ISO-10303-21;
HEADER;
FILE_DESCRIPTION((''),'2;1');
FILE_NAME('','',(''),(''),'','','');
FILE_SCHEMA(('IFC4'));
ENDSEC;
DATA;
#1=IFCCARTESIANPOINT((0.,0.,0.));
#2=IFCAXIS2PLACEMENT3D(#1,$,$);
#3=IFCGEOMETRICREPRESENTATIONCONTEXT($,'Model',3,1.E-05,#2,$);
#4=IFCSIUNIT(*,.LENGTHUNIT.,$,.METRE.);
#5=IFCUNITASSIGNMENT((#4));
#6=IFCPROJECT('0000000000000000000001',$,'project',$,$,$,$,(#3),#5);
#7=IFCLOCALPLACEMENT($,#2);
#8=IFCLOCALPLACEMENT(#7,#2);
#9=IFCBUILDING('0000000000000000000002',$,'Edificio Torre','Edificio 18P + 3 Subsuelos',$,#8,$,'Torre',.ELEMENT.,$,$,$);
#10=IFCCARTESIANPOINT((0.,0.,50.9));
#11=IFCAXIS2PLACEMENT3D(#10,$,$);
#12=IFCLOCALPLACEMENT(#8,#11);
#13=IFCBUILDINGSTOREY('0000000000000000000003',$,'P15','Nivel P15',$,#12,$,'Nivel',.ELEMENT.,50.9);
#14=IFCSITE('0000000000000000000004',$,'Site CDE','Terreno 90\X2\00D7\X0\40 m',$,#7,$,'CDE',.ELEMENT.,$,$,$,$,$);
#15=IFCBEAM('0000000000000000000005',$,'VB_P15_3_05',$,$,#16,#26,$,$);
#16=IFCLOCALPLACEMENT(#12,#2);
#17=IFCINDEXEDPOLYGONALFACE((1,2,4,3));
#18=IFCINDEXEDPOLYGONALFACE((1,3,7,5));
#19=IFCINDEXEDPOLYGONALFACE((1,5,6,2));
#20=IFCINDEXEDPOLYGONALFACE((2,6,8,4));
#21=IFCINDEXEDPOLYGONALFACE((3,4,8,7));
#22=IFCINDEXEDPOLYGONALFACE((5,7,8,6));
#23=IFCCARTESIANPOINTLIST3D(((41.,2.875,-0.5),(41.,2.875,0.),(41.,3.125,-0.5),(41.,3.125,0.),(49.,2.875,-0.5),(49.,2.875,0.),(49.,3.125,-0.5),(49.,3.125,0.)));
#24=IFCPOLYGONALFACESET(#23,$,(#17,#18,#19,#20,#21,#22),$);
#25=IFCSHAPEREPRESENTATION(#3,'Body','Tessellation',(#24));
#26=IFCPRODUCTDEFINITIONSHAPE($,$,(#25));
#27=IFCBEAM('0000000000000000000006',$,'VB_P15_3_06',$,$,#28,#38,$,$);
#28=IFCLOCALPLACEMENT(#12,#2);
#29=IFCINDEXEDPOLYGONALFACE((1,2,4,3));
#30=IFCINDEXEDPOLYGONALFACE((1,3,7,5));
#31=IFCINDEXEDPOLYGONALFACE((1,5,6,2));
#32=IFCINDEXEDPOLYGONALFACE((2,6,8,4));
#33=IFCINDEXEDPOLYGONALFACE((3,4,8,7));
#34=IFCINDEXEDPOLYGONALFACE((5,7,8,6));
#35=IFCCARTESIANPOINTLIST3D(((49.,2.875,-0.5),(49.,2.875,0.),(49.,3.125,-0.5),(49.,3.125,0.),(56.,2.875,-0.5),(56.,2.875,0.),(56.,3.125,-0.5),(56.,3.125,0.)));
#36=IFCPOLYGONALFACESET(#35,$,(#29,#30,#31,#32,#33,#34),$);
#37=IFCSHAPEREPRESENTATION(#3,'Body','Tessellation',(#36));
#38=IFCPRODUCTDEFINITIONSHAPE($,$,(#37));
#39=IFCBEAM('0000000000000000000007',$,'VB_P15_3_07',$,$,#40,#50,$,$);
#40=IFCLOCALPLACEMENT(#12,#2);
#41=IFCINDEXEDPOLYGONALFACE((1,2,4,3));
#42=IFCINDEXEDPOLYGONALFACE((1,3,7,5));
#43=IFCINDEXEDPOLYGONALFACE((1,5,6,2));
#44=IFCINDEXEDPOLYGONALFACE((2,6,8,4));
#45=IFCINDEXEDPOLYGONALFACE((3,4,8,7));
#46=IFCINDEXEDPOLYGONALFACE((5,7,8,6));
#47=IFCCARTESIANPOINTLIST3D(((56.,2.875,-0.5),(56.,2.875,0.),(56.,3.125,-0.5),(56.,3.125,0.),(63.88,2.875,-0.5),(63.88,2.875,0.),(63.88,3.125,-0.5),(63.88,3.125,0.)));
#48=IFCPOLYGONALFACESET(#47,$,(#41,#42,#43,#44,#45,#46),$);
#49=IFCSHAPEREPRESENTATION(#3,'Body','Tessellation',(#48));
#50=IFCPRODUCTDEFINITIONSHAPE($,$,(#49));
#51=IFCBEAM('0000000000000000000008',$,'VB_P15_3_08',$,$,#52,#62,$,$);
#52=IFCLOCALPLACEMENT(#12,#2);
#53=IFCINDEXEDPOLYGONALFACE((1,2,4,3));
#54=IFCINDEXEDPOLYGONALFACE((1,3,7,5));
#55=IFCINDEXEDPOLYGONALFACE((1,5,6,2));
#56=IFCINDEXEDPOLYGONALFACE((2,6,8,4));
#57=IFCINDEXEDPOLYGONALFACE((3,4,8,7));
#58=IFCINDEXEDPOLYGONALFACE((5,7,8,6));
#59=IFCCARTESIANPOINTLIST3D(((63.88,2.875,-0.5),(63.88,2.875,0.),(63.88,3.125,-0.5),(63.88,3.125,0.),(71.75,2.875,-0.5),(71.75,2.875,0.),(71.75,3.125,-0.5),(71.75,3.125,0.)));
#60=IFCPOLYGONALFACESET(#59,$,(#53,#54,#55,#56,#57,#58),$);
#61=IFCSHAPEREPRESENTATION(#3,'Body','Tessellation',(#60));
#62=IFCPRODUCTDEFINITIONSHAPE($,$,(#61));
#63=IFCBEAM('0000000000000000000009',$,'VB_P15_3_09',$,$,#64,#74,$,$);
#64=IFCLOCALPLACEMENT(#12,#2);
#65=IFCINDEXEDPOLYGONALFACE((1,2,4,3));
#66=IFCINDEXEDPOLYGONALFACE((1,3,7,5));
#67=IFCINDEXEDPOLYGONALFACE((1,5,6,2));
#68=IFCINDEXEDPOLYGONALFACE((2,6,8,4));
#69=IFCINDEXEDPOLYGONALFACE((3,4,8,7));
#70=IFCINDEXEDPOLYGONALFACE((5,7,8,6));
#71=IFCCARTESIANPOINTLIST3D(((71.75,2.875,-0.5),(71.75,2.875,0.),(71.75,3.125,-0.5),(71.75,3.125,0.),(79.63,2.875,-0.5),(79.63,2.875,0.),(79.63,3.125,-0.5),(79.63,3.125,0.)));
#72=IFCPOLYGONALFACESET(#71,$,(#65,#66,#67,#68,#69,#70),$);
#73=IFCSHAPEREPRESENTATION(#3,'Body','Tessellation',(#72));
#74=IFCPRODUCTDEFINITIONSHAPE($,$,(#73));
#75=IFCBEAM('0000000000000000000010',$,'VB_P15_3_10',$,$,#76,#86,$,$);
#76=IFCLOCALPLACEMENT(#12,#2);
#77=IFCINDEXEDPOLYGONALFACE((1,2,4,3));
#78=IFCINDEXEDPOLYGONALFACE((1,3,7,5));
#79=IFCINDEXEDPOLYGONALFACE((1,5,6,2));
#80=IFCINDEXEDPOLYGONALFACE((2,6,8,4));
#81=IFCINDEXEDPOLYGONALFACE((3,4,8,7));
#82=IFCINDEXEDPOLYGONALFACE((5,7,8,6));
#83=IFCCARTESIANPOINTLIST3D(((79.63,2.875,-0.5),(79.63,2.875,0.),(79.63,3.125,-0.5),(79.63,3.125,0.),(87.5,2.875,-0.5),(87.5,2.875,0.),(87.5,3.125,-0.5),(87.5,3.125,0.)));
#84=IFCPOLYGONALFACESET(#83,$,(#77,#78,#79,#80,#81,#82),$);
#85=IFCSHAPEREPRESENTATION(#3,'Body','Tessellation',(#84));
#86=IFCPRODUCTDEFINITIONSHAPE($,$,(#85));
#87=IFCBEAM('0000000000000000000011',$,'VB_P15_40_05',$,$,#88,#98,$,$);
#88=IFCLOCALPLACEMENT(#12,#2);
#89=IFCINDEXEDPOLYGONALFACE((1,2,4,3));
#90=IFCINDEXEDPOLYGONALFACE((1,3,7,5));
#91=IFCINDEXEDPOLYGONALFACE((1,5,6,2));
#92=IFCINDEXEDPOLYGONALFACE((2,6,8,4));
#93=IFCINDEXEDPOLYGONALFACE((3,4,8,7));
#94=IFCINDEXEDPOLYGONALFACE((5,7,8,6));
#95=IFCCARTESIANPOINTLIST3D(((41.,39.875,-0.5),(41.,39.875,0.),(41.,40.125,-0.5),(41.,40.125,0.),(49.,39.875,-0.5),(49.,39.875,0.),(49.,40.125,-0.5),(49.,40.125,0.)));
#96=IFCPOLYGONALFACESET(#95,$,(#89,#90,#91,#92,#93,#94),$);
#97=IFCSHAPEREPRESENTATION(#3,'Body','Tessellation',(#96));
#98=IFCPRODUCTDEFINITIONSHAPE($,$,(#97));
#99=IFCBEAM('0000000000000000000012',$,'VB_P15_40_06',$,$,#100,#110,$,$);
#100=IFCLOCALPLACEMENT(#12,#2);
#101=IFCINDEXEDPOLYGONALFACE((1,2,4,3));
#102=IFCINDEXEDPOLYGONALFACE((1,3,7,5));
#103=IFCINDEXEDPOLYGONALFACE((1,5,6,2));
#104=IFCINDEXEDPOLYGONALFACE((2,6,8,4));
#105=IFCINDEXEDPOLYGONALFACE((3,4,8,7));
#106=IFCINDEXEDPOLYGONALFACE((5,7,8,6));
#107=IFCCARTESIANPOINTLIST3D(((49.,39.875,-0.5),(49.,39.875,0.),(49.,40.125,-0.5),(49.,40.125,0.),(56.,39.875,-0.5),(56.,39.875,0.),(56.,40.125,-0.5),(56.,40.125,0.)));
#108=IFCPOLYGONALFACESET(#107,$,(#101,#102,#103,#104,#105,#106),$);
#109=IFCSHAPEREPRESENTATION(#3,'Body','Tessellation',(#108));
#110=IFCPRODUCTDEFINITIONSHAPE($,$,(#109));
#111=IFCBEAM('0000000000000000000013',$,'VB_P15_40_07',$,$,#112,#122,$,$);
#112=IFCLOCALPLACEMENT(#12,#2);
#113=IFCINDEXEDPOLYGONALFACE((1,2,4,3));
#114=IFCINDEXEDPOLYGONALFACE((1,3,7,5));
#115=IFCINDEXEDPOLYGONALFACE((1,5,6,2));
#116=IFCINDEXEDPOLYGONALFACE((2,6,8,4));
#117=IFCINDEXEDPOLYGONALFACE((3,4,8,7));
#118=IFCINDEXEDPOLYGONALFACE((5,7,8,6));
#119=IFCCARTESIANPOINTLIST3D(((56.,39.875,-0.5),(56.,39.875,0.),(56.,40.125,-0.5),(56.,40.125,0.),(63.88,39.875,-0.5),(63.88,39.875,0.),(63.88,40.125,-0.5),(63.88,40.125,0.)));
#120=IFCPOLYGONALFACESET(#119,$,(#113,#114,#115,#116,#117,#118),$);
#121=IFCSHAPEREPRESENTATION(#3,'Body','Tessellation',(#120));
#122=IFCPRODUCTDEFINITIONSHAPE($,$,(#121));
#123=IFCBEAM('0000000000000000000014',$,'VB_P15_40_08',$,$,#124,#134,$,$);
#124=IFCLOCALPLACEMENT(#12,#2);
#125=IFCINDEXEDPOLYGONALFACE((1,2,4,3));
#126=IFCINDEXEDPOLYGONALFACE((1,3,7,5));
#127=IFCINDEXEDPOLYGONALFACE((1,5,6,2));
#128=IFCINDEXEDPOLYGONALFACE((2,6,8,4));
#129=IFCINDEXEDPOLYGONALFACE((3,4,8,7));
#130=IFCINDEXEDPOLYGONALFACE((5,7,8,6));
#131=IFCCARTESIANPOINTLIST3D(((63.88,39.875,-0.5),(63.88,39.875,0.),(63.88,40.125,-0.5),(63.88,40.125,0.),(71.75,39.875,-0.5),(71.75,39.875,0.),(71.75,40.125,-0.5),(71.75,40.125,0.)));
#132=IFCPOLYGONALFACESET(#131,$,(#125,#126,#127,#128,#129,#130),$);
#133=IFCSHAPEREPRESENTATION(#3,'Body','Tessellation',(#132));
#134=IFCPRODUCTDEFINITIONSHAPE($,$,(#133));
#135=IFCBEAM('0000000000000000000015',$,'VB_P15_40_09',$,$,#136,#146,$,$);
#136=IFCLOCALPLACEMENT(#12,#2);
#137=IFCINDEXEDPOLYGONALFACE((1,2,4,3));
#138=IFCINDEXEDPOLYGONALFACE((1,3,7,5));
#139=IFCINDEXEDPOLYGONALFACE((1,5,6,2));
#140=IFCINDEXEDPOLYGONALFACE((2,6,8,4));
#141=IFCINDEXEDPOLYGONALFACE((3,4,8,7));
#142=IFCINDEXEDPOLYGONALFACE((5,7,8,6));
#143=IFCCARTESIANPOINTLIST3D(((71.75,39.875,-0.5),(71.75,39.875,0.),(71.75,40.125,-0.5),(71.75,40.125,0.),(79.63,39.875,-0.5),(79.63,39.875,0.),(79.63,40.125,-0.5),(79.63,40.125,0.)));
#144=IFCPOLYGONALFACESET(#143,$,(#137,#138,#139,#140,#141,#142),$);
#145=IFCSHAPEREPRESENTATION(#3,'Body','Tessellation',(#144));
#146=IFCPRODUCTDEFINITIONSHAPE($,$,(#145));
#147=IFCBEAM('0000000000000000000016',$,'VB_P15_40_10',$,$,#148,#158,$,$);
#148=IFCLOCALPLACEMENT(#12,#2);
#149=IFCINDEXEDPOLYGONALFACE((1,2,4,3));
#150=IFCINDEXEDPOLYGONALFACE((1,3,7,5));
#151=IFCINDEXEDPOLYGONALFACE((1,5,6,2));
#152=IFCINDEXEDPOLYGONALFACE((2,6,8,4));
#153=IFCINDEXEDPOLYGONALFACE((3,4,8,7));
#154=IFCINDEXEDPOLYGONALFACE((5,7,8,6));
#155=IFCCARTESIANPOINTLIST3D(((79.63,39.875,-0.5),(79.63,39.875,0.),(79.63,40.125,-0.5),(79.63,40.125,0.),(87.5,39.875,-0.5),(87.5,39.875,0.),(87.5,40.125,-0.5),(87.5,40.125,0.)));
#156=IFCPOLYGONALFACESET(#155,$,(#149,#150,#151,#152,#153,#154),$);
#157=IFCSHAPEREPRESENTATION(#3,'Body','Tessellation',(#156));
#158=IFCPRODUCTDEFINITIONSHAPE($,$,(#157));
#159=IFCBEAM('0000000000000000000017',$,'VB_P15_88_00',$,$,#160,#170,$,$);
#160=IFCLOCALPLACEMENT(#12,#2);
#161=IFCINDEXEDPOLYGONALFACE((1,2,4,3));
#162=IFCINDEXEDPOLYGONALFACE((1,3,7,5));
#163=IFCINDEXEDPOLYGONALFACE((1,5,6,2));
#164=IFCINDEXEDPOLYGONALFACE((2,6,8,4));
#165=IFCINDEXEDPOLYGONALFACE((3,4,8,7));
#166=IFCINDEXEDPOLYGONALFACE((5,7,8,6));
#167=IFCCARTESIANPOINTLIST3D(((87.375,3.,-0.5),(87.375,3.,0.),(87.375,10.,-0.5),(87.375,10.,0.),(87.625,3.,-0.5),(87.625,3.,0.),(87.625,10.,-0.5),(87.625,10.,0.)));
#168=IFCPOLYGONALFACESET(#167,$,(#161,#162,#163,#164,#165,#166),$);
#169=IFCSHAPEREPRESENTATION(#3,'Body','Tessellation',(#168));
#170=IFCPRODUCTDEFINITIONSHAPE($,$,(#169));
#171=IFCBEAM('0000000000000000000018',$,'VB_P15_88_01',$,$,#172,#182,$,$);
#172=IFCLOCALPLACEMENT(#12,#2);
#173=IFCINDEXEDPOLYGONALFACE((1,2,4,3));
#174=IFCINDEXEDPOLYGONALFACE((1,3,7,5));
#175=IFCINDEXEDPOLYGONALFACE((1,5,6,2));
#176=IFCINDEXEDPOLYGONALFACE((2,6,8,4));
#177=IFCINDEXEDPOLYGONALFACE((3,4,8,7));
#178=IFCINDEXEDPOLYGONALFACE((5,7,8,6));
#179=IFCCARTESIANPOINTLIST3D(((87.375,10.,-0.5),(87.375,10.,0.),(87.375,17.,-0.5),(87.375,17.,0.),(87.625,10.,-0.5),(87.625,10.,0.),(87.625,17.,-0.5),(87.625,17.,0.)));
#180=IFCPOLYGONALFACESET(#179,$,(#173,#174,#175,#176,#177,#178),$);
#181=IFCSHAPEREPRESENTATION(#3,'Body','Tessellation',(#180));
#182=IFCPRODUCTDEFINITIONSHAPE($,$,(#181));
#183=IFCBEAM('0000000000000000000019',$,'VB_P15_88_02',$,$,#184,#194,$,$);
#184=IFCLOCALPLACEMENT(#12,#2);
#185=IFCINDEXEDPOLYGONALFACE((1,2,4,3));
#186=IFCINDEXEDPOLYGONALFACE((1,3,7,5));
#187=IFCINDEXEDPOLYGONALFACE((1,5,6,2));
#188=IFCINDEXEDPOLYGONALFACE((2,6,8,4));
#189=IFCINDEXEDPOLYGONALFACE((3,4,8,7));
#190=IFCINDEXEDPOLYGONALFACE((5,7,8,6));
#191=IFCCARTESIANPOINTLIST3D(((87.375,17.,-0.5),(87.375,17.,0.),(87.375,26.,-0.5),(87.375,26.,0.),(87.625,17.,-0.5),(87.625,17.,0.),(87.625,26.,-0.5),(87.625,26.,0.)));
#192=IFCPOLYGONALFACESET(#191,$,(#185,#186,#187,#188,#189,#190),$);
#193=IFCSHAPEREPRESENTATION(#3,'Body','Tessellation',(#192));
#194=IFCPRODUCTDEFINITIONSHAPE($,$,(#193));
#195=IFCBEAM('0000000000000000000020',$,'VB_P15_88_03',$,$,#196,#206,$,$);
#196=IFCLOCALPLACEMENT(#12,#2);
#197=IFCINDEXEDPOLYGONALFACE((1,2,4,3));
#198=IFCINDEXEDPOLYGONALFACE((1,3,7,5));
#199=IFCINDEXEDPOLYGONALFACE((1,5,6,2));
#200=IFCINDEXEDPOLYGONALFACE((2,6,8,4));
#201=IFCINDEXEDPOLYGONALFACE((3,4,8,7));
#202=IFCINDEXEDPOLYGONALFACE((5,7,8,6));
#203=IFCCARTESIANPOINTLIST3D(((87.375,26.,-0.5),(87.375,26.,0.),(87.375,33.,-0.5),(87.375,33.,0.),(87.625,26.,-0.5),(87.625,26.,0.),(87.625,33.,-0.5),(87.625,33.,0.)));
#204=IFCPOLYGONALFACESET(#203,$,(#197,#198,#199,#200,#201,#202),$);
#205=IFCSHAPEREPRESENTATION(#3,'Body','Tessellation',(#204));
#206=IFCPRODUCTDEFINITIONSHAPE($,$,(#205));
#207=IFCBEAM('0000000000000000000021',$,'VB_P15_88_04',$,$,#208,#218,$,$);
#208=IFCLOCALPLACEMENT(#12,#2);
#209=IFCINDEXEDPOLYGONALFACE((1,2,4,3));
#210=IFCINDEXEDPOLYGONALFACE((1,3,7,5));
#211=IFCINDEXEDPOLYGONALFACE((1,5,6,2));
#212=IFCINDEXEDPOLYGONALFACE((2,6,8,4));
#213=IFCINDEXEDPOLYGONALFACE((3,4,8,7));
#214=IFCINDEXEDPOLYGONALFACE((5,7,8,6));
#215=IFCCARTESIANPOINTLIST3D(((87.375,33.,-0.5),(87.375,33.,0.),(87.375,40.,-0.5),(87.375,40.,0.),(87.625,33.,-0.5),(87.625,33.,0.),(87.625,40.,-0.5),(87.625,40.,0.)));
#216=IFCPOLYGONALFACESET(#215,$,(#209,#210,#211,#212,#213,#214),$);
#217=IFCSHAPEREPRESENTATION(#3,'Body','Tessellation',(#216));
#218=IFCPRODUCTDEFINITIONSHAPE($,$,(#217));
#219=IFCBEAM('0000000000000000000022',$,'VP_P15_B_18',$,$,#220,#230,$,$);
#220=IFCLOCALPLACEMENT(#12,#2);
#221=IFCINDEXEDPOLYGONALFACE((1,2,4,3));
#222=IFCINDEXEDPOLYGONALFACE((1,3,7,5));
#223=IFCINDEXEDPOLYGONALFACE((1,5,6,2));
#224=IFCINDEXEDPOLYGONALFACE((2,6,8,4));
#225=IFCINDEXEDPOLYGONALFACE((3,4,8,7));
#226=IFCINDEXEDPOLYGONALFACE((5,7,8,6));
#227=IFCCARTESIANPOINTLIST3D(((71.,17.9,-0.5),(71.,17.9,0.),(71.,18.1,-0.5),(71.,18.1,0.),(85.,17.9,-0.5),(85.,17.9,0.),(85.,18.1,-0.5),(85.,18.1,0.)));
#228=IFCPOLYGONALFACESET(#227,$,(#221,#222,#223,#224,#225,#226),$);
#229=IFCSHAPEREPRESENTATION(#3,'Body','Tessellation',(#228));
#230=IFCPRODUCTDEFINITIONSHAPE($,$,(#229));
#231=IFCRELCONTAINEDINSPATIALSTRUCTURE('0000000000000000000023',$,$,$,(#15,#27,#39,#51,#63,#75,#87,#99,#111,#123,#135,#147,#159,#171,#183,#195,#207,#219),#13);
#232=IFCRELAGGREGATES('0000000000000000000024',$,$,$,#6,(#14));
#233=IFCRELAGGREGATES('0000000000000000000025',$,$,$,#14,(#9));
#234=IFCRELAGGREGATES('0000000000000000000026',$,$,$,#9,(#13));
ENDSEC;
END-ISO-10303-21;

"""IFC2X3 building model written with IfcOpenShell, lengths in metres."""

from ifc_helpers import new_model, si_unit, frame, origin, origin_2d, place, context, project, spatial, rectangle, extrude, element, save


model = new_model("IFC2X3")

# Units and contexts
model_context = context("Model", 3, precision=1e-05, world=origin())
ifc_project = project(units=[si_unit("LENGTHUNIT", "METRE")], contexts=[model_context])

# Site, building, storey
site_placement = place(None, origin())
site = spatial("IfcSite", under=ifc_project, at=site_placement, Name="Site CDE", Description="Terreno 90×40 m", LongName="CDE", CompositionType="ELEMENT")
building_placement = place(site_placement, origin())
building = spatial("IfcBuilding", under=site, at=building_placement, Name="Edificio Torre", Description="Edificio 18P + 3 Subsuelos", LongName="Torre", CompositionType="ELEMENT")
storey_placement = place(building_placement, frame((0.0, 0.0, 50.9)))
storey = spatial("IfcBuildingStorey", under=building, at=storey_placement, Name="P15", Description="Nivel P15", LongName="Nivel", CompositionType="ELEMENT", Elevation=50.9)

# Beams
beam_1_placement = place(storey_placement, frame((45.0, 3.0, -0.5)))
element("IfcBeam", 1, at=beam_1_placement, inside=storey, Name="VB_P15_3_05", context=model_context, shape_type="SweptSolid", body=[
    extrude(rectangle(XDim=8.0, YDim=0.25, at=origin_2d()), origin(), (0.0, 0.0, 1.0), 0.5),
])
beam_2_placement = place(storey_placement, frame((52.5, 3.0, -0.5)))
element("IfcBeam", 2, at=beam_2_placement, inside=storey, Name="VB_P15_3_06", context=model_context, shape_type="SweptSolid", body=[
    extrude(rectangle(XDim=7.0, YDim=0.25, at=origin_2d()), origin(), (0.0, 0.0, 1.0), 0.5),
])
beam_3_placement = place(storey_placement, frame((59.94, 3.0, -0.5)))
element("IfcBeam", 3, at=beam_3_placement, inside=storey, Name="VB_P15_3_07", context=model_context, shape_type="SweptSolid", body=[
    extrude(rectangle(XDim=7.88, YDim=0.25, at=origin_2d()), origin(), (0.0, 0.0, 1.0), 0.5),
])
beam_4_placement = place(storey_placement, frame((67.815, 3.0, -0.5)))
element("IfcBeam", 4, at=beam_4_placement, inside=storey, Name="VB_P15_3_08", context=model_context, shape_type="SweptSolid", body=[
    extrude(rectangle(XDim=7.87, YDim=0.25, at=origin_2d()), origin(), (0.0, 0.0, 1.0), 0.5),
])
beam_5_placement = place(storey_placement, frame((75.69, 3.0, -0.5)))
element("IfcBeam", 5, at=beam_5_placement, inside=storey, Name="VB_P15_3_09", context=model_context, shape_type="SweptSolid", body=[
    extrude(rectangle(XDim=7.88, YDim=0.25, at=origin_2d()), origin(), (0.0, 0.0, 1.0), 0.5),
])
beam_6_placement = place(storey_placement, frame((83.565, 3.0, -0.5)))
element("IfcBeam", 6, at=beam_6_placement, inside=storey, Name="VB_P15_3_10", context=model_context, shape_type="SweptSolid", body=[
    extrude(rectangle(XDim=7.87, YDim=0.25, at=origin_2d()), origin(), (0.0, 0.0, 1.0), 0.5),
])
beam_7_placement = place(storey_placement, frame((45.0, 40.0, -0.5)))
element("IfcBeam", 7, at=beam_7_placement, inside=storey, Name="VB_P15_40_05", context=model_context, shape_type="SweptSolid", body=[
    extrude(rectangle(XDim=8.0, YDim=0.25, at=origin_2d()), origin(), (0.0, 0.0, 1.0), 0.5),
])
beam_8_placement = place(storey_placement, frame((52.5, 40.0, -0.5)))
element("IfcBeam", 8, at=beam_8_placement, inside=storey, Name="VB_P15_40_06", context=model_context, shape_type="SweptSolid", body=[
    extrude(rectangle(XDim=7.0, YDim=0.25, at=origin_2d()), origin(), (0.0, 0.0, 1.0), 0.5),
])
beam_9_placement = place(storey_placement, frame((59.94, 40.0, -0.5)))
element("IfcBeam", 9, at=beam_9_placement, inside=storey, Name="VB_P15_40_07", context=model_context, shape_type="SweptSolid", body=[
    extrude(rectangle(XDim=7.88, YDim=0.25, at=origin_2d()), origin(), (0.0, 0.0, 1.0), 0.5),
])
beam_10_placement = place(storey_placement, frame((67.815, 40.0, -0.5)))
element("IfcBeam", 10, at=beam_10_placement, inside=storey, Name="VB_P15_40_08", context=model_context, shape_type="SweptSolid", body=[
    extrude(rectangle(XDim=7.87, YDim=0.25, at=origin_2d()), origin(), (0.0, 0.0, 1.0), 0.5),
])
beam_11_placement = place(storey_placement, frame((75.69, 40.0, -0.5)))
element("IfcBeam", 11, at=beam_11_placement, inside=storey, Name="VB_P15_40_09", context=model_context, shape_type="SweptSolid", body=[
    extrude(rectangle(XDim=7.88, YDim=0.25, at=origin_2d()), origin(), (0.0, 0.0, 1.0), 0.5),
])
beam_12_placement = place(storey_placement, frame((83.565, 40.0, -0.5)))
element("IfcBeam", 12, at=beam_12_placement, inside=storey, Name="VB_P15_40_10", context=model_context, shape_type="SweptSolid", body=[
    extrude(rectangle(XDim=7.87, YDim=0.25, at=origin_2d()), origin(), (0.0, 0.0, 1.0), 0.5),
])
for number, where, name in (
    (13, (87.5, 6.5, -0.5), "VB_P15_88_00"),
    (14, (87.5, 13.5, -0.5), "VB_P15_88_01"),
):
    element("IfcBeam", number, at=place(storey_placement, frame(where)), inside=storey, Name=name, context=model_context, shape_type="SweptSolid", body=[
        extrude(rectangle(XDim=0.25, YDim=7.0, at=origin_2d()), origin(), (0.0, 0.0, 1.0), 0.5),
    ])
beam_13_placement = place(storey_placement, frame((87.5, 21.5, -0.5)))
element("IfcBeam", 15, at=beam_13_placement, inside=storey, Name="VB_P15_88_02", context=model_context, shape_type="SweptSolid", body=[
    extrude(rectangle(XDim=0.25, YDim=9.0, at=origin_2d()), origin(), (0.0, 0.0, 1.0), 0.5),
])
for number, where, name in (
    (16, (87.5, 29.5, -0.5), "VB_P15_88_03"),
    (17, (87.5, 36.5, -0.5), "VB_P15_88_04"),
):
    element("IfcBeam", number, at=place(storey_placement, frame(where)), inside=storey, Name=name, context=model_context, shape_type="SweptSolid", body=[
        extrude(rectangle(XDim=0.25, YDim=7.0, at=origin_2d()), origin(), (0.0, 0.0, 1.0), 0.5),
    ])
for number, where, name in (
    (18, (78.0, 18.0, -0.5), "VP_P15_B_18"),
):
    element("IfcBeam", number, at=place(storey_placement, frame(where)), inside=storey, Name=name, context=model_context, shape_type="SweptSolid", body=[
        extrude(rectangle(XDim=14.0, YDim=0.2, at=origin_2d()), origin(), (0.0, 0.0, 1.0), 0.5),
    ])

save(model, "model.ifc")
